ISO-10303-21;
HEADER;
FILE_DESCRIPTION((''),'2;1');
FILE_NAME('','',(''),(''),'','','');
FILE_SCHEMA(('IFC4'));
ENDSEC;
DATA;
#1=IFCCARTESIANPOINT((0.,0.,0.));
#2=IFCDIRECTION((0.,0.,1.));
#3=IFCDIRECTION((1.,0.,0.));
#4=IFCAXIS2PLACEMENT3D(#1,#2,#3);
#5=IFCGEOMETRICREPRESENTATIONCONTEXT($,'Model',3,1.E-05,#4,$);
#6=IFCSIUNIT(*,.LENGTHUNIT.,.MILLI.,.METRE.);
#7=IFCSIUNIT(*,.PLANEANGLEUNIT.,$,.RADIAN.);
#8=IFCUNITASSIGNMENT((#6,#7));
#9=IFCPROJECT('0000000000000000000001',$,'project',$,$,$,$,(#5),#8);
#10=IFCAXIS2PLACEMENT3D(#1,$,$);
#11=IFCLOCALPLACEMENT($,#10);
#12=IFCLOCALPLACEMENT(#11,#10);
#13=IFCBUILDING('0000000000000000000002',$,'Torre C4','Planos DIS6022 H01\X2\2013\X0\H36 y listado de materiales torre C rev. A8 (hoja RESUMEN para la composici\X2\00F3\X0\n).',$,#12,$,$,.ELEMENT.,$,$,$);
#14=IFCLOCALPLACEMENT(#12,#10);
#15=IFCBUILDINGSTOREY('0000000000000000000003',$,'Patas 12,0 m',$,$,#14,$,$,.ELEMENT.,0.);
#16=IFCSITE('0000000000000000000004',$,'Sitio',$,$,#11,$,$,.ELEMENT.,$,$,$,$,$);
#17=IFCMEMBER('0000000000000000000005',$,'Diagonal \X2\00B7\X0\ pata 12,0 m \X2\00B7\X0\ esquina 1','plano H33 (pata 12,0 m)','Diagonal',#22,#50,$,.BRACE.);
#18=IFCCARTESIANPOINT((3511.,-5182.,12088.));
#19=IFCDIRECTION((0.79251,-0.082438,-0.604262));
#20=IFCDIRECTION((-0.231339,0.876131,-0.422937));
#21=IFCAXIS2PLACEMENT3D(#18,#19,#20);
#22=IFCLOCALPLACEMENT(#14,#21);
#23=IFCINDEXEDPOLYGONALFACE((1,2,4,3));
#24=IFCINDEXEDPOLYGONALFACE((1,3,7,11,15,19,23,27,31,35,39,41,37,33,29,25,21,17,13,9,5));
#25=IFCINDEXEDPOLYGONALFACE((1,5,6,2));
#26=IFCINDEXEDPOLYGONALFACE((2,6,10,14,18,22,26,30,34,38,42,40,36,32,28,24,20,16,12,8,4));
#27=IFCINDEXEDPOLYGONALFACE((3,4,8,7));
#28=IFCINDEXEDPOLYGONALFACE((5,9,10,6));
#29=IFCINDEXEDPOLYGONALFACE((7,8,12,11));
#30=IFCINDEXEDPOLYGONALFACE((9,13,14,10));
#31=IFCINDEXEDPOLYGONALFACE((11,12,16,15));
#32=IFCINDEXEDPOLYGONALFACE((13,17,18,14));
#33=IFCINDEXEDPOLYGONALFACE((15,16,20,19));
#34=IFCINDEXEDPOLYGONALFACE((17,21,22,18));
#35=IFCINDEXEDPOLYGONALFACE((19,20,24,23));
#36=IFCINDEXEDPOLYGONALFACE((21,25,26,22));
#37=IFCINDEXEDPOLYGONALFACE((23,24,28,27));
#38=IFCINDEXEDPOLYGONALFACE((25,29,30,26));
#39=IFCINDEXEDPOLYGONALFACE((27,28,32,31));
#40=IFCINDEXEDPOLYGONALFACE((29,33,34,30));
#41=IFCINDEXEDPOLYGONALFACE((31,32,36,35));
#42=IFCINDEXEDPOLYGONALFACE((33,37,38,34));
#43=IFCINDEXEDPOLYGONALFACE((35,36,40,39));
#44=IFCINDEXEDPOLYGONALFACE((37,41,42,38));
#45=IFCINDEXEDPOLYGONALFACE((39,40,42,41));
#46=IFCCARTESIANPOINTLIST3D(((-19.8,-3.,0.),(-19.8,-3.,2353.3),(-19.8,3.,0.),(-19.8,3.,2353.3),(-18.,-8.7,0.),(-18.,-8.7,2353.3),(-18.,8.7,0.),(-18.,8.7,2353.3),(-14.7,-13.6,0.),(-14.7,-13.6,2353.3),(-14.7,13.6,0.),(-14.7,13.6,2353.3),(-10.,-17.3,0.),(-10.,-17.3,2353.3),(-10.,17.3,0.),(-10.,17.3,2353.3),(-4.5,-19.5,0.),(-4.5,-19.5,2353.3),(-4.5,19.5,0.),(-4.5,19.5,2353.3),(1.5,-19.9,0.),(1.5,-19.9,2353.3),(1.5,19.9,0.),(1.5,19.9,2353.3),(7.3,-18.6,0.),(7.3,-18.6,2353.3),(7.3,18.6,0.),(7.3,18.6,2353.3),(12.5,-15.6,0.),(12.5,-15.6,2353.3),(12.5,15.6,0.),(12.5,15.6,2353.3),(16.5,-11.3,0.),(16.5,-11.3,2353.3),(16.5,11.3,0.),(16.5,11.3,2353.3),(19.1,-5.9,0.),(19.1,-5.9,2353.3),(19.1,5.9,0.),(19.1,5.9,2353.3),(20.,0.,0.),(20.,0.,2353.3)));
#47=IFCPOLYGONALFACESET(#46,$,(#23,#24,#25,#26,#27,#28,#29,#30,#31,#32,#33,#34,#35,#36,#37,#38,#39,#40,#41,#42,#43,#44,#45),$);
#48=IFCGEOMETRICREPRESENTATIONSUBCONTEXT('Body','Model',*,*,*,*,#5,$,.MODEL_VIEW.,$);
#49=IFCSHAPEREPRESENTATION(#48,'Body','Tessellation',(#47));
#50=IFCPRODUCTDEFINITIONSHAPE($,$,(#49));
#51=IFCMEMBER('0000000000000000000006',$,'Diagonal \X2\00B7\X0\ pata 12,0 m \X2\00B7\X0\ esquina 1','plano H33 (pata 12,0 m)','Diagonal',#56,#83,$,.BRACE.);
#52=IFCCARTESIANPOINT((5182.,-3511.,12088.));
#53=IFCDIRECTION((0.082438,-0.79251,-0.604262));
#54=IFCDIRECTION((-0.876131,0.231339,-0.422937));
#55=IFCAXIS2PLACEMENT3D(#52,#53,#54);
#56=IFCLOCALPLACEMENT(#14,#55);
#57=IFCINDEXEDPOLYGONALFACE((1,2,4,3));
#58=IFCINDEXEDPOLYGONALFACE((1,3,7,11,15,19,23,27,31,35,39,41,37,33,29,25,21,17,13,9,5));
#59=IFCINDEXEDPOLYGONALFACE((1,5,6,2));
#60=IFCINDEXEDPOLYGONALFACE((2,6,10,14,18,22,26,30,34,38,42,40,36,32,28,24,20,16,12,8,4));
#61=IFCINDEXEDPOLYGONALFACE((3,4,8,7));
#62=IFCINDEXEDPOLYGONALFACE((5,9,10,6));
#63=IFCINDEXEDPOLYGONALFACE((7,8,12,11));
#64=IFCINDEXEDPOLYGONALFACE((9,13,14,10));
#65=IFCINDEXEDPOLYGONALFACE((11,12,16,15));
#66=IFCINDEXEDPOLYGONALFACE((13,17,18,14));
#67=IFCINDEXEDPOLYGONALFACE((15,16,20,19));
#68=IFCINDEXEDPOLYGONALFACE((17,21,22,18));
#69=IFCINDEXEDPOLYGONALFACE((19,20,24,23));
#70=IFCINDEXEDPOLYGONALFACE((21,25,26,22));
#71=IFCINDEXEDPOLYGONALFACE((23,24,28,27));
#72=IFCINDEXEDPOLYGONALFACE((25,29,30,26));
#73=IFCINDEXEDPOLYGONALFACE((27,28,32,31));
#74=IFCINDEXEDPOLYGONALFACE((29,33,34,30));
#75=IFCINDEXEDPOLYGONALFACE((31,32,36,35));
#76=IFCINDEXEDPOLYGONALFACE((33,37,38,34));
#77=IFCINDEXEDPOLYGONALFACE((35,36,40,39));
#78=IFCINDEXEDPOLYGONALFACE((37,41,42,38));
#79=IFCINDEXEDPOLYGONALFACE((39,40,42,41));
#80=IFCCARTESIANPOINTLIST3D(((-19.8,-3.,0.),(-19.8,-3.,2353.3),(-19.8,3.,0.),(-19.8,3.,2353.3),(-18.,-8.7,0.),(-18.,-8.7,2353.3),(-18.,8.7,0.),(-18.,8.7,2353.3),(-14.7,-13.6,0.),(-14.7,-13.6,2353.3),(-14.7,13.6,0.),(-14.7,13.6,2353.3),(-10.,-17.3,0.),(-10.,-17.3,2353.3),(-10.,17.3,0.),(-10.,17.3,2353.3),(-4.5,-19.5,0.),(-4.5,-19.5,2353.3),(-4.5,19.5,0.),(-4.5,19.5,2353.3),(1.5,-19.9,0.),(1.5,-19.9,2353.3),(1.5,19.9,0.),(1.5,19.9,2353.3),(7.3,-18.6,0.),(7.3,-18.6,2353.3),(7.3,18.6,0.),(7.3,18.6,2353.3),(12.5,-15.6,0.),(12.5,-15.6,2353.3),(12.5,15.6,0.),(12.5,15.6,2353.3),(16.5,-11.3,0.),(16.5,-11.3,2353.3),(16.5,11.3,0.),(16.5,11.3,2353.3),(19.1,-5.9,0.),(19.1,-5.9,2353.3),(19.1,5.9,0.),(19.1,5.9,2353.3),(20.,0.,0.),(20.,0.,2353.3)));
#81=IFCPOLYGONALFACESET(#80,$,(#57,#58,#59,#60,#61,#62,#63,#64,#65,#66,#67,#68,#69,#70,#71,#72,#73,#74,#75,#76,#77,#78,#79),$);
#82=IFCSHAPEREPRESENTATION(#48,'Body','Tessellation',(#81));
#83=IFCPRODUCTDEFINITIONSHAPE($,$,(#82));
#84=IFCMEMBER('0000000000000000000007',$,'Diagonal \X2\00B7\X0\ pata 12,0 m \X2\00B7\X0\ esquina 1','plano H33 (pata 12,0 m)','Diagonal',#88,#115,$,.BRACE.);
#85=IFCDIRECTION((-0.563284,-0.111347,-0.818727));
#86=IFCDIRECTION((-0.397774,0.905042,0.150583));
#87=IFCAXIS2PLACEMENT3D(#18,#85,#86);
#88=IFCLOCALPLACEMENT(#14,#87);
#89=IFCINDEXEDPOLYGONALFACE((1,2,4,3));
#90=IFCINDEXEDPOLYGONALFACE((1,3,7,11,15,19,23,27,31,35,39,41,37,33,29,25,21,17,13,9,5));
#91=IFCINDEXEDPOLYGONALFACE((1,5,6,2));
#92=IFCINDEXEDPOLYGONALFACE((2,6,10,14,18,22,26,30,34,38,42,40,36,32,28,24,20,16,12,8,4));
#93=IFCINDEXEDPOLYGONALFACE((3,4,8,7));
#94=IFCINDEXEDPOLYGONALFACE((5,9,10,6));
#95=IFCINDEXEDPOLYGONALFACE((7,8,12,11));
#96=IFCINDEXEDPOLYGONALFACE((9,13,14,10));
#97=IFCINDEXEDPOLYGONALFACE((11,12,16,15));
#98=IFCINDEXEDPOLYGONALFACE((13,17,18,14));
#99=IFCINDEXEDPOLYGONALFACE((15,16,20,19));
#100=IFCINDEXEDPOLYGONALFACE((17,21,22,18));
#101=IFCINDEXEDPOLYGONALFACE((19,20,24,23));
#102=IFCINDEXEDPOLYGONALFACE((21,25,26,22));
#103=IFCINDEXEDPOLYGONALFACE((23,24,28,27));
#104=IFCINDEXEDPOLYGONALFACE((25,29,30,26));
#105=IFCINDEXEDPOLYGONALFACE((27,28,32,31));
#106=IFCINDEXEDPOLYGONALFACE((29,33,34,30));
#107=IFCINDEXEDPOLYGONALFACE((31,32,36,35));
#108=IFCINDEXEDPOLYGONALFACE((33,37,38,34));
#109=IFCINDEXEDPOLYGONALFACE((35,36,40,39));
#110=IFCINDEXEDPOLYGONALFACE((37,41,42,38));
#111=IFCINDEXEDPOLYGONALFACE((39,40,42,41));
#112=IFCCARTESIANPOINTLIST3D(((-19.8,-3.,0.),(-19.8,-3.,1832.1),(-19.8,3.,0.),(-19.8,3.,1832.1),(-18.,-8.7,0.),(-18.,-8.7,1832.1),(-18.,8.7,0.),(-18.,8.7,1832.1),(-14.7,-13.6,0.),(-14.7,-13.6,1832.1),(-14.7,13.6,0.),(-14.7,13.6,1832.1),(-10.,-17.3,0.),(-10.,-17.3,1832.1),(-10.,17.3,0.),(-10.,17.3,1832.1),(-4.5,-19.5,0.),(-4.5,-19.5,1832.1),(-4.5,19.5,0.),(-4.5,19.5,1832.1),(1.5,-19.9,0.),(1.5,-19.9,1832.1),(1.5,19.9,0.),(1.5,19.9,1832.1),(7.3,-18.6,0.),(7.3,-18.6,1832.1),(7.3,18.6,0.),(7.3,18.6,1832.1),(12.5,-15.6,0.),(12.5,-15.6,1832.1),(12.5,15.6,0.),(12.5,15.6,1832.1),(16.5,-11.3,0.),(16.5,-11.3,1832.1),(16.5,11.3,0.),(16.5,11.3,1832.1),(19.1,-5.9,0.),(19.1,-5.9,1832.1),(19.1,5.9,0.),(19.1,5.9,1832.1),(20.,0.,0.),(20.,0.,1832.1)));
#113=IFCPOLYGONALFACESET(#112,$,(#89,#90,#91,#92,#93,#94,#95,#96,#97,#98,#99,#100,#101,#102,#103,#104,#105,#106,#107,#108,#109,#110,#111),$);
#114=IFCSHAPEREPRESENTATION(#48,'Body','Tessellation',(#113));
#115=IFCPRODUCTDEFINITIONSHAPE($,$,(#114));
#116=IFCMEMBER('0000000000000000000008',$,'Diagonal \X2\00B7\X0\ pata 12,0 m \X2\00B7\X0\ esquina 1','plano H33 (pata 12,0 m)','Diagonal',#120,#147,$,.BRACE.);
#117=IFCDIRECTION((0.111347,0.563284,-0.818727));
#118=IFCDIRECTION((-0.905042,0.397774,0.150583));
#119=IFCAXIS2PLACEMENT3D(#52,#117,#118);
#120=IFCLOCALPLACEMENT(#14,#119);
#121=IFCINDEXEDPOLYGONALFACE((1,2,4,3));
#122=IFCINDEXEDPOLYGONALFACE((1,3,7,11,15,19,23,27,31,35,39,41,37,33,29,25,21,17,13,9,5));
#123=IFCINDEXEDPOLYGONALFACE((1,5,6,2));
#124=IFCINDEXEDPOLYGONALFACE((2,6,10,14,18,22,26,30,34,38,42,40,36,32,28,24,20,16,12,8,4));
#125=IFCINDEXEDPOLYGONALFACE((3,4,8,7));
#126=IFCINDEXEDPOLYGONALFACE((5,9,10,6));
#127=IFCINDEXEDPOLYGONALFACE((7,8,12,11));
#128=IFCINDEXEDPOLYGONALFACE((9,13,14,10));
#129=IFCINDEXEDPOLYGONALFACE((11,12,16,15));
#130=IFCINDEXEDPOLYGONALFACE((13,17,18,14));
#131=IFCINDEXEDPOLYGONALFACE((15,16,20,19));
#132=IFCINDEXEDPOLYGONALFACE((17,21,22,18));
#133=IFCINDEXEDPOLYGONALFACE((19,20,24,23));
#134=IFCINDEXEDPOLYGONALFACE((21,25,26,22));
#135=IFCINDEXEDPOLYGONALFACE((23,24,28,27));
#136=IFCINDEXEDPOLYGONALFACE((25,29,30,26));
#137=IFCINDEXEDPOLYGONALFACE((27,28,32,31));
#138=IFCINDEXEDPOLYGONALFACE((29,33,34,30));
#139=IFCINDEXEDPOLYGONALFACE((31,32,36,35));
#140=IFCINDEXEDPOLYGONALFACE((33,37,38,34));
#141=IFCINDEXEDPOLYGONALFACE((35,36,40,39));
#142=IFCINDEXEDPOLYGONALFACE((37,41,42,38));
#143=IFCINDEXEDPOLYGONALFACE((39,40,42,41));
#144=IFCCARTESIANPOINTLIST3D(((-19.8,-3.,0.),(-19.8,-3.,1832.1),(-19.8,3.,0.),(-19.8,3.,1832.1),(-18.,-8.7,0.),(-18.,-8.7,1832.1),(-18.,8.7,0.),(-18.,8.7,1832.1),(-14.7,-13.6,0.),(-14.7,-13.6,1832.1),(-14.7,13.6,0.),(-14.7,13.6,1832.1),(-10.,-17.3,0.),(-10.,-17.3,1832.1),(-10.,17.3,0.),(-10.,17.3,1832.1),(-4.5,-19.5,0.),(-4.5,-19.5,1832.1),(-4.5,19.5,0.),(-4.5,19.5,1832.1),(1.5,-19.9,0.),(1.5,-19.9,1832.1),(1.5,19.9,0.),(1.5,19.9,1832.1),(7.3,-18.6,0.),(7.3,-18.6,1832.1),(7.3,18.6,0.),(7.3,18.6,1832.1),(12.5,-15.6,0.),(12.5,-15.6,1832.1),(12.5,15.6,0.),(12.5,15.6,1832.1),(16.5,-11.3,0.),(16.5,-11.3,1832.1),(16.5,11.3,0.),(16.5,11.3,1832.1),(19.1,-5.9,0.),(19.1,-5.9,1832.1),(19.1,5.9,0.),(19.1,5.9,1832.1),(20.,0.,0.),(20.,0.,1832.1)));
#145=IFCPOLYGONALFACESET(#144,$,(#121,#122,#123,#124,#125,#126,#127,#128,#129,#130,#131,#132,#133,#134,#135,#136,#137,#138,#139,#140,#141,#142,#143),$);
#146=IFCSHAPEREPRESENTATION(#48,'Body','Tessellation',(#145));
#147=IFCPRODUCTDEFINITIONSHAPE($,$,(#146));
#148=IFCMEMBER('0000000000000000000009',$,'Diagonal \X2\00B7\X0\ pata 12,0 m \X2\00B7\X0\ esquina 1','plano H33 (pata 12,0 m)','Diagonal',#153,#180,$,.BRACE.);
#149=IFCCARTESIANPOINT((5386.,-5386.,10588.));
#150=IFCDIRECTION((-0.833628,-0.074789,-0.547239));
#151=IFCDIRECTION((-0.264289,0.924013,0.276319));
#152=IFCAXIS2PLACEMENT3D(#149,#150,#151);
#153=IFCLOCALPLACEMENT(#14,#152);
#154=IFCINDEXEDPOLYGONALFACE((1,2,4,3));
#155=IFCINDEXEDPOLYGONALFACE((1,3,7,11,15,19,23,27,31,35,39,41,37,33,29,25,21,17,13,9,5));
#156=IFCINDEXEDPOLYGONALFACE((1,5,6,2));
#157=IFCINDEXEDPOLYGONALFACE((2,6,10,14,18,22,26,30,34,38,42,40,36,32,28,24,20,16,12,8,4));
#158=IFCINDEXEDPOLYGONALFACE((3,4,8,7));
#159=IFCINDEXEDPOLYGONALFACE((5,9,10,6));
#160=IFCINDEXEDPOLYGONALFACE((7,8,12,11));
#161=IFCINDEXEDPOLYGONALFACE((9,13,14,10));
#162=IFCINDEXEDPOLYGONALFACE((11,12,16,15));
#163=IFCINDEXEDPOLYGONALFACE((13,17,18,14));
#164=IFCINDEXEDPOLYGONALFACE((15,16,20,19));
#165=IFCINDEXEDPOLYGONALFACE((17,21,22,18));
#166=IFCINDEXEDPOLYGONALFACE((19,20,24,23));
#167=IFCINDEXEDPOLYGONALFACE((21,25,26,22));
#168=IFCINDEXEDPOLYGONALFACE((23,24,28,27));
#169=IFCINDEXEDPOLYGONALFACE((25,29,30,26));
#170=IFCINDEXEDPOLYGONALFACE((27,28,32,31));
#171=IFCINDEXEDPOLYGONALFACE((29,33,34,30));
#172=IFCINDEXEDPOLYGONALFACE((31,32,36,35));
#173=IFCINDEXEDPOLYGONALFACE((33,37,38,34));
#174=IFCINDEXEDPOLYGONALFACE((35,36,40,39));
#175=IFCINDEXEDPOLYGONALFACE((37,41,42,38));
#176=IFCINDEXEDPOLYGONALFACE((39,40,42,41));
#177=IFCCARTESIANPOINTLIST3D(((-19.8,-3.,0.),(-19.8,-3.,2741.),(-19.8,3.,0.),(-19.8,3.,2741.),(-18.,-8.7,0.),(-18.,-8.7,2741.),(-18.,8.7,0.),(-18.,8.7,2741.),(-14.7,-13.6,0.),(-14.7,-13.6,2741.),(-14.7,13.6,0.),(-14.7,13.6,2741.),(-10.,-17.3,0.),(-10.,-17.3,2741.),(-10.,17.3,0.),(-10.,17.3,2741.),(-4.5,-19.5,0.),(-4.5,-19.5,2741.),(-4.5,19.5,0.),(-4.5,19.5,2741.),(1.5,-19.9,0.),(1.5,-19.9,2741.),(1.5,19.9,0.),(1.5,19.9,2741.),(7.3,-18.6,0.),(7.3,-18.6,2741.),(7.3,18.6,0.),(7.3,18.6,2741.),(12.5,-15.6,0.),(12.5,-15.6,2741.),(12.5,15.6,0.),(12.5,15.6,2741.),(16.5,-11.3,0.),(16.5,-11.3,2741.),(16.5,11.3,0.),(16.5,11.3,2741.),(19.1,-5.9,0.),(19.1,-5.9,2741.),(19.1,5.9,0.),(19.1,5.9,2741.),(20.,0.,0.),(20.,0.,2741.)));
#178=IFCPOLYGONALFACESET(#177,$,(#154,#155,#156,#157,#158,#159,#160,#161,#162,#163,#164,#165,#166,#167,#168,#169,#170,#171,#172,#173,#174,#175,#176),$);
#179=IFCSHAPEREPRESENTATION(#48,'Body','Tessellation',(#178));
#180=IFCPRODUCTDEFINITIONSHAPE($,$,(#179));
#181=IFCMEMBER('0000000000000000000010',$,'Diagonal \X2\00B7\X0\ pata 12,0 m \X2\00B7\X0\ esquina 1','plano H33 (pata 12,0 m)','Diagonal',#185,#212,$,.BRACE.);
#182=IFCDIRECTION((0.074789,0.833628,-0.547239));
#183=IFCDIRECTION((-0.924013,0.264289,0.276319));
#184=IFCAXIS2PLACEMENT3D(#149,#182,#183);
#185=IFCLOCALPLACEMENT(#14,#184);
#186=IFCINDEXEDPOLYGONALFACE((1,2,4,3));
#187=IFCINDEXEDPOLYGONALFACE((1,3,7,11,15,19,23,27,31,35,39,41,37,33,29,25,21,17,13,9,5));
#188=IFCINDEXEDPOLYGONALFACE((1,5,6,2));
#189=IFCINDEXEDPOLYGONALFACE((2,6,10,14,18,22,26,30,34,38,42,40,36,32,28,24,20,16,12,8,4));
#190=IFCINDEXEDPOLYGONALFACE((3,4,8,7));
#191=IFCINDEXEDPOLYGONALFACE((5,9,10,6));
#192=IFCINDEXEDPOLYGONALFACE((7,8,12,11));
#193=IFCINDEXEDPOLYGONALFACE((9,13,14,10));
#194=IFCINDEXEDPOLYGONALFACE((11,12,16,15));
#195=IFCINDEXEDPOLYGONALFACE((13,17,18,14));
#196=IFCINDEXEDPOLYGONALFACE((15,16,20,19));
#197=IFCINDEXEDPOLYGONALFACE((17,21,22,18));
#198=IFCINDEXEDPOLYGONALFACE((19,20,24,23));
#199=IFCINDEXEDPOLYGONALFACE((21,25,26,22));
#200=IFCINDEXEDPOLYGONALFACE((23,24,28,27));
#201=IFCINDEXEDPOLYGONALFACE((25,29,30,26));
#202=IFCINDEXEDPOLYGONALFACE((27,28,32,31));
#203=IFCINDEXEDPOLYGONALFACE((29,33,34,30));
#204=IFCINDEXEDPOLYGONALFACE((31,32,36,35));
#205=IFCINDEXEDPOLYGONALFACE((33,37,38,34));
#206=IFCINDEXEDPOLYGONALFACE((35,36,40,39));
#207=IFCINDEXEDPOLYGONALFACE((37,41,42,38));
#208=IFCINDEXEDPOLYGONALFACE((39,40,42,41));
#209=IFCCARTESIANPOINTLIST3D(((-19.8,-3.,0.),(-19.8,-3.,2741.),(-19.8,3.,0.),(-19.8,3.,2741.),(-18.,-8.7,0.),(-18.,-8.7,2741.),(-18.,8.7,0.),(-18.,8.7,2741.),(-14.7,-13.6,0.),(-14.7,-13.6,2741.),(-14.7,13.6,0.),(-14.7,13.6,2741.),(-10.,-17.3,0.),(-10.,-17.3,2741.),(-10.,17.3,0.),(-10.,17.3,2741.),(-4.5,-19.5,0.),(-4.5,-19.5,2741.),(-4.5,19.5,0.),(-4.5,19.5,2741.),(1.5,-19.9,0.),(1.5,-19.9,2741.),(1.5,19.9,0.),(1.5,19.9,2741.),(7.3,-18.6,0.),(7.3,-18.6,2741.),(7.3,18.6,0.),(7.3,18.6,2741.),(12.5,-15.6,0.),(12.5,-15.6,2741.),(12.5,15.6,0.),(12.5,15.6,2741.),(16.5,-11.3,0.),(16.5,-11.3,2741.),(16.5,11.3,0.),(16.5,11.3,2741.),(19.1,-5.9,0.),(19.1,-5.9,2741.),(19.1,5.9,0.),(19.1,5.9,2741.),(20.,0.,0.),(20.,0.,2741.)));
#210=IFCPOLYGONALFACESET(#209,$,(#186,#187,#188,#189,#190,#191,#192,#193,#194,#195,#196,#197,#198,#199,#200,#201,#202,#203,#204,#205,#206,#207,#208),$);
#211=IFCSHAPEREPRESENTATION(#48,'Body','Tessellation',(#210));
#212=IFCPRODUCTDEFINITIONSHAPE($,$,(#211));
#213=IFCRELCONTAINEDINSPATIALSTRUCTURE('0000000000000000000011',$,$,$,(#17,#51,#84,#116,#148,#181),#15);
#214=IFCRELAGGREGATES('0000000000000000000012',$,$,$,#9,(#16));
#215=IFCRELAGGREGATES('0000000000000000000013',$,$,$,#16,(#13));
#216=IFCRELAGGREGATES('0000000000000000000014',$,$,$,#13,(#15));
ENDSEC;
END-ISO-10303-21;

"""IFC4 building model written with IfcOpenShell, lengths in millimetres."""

from ifc_helpers import new_model, si_unit, frame, origin, origin_with_axes, place, context, subcontext, project, spatial, circle, extrude, element, save


model = new_model("IFC4")

# Units and contexts
model_context = context("Model", 3, precision=1e-05, world=origin_with_axes())
body_context = subcontext(model_context, "Body", "Model", "MODEL_VIEW")
ifc_project = project(units=[si_unit("LENGTHUNIT", "METRE", prefix="MILLI"), si_unit("PLANEANGLEUNIT", "RADIAN")], contexts=[model_context])

# Site, building, storey
site_placement = place(None, origin())
site = spatial("IfcSite", under=ifc_project, at=site_placement, Name="Sitio", CompositionType="ELEMENT")
building_placement = place(site_placement, origin())
building = spatial("IfcBuilding", under=site, at=building_placement, Name="Torre C4", Description="Planos DIS6022 H01–H36 y listado de materiales torre C rev. A8 (hoja RESUMEN para la composición).", CompositionType="ELEMENT")
storey_placement = place(building_placement, origin())
storey = spatial("IfcBuildingStorey", under=building, at=storey_placement, Name="Patas 12,0 m", CompositionType="ELEMENT", Elevation=0.0)

# Members
for number, where, z_axis, x_axis, name in (
    (1, (3511.0, -5182.0, 12088.0), (0.79251, -0.082438, -0.604262), (-0.231339, 0.876131, -0.422937), "Diagonal · pata 12,0 m · esquina 1"),
    (2, (5182.0, -3511.0, 12088.0), (0.082438, -0.79251, -0.604262), (-0.876131, 0.231339, -0.422937), "Diagonal · pata 12,0 m · esquina 1"),
):
    element("IfcMember", number, at=place(storey_placement, frame(where, z_axis=z_axis, x_axis=x_axis)), inside=storey, Name=name, Description="plano H33 (pata 12,0 m)", ObjectType="Diagonal", PredefinedType="BRACE", context=body_context, shape_type="SweptSolid", body=[
        extrude(circle(Radius=20.0), None, (0.0, 0.0, 1.0), 2353.3),
    ])
for number, where, z_axis, x_axis, name in (
    (3, (3511.0, -5182.0, 12088.0), (-0.563284, -0.111347, -0.818727), (-0.397774, 0.905042, 0.150583), "Diagonal · pata 12,0 m · esquina 1"),
    (4, (5182.0, -3511.0, 12088.0), (0.111347, 0.563284, -0.818727), (-0.905042, 0.397774, 0.150583), "Diagonal · pata 12,0 m · esquina 1"),
):
    element("IfcMember", number, at=place(storey_placement, frame(where, z_axis=z_axis, x_axis=x_axis)), inside=storey, Name=name, Description="plano H33 (pata 12,0 m)", ObjectType="Diagonal", PredefinedType="BRACE", context=body_context, shape_type="SweptSolid", body=[
        extrude(circle(Radius=20.0), None, (0.0, 0.0, 1.0), 1832.1),
    ])
for number, where, z_axis, x_axis, name in (
    (5, (5386.0, -5386.0, 10588.0), (-0.833628, -0.074789, -0.547239), (-0.264289, 0.924013, 0.276319), "Diagonal · pata 12,0 m · esquina 1"),
    (6, (5386.0, -5386.0, 10588.0), (0.074789, 0.833628, -0.547239), (-0.924013, 0.264289, 0.276319), "Diagonal · pata 12,0 m · esquina 1"),
):
    element("IfcMember", number, at=place(storey_placement, frame(where, z_axis=z_axis, x_axis=x_axis)), inside=storey, Name=name, Description="plano H33 (pata 12,0 m)", ObjectType="Diagonal", PredefinedType="BRACE", context=body_context, shape_type="SweptSolid", body=[
        extrude(circle(Radius=20.0), None, (0.0, 0.0, 1.0), 2741.0),
    ])

save(model, "model.ifc")
